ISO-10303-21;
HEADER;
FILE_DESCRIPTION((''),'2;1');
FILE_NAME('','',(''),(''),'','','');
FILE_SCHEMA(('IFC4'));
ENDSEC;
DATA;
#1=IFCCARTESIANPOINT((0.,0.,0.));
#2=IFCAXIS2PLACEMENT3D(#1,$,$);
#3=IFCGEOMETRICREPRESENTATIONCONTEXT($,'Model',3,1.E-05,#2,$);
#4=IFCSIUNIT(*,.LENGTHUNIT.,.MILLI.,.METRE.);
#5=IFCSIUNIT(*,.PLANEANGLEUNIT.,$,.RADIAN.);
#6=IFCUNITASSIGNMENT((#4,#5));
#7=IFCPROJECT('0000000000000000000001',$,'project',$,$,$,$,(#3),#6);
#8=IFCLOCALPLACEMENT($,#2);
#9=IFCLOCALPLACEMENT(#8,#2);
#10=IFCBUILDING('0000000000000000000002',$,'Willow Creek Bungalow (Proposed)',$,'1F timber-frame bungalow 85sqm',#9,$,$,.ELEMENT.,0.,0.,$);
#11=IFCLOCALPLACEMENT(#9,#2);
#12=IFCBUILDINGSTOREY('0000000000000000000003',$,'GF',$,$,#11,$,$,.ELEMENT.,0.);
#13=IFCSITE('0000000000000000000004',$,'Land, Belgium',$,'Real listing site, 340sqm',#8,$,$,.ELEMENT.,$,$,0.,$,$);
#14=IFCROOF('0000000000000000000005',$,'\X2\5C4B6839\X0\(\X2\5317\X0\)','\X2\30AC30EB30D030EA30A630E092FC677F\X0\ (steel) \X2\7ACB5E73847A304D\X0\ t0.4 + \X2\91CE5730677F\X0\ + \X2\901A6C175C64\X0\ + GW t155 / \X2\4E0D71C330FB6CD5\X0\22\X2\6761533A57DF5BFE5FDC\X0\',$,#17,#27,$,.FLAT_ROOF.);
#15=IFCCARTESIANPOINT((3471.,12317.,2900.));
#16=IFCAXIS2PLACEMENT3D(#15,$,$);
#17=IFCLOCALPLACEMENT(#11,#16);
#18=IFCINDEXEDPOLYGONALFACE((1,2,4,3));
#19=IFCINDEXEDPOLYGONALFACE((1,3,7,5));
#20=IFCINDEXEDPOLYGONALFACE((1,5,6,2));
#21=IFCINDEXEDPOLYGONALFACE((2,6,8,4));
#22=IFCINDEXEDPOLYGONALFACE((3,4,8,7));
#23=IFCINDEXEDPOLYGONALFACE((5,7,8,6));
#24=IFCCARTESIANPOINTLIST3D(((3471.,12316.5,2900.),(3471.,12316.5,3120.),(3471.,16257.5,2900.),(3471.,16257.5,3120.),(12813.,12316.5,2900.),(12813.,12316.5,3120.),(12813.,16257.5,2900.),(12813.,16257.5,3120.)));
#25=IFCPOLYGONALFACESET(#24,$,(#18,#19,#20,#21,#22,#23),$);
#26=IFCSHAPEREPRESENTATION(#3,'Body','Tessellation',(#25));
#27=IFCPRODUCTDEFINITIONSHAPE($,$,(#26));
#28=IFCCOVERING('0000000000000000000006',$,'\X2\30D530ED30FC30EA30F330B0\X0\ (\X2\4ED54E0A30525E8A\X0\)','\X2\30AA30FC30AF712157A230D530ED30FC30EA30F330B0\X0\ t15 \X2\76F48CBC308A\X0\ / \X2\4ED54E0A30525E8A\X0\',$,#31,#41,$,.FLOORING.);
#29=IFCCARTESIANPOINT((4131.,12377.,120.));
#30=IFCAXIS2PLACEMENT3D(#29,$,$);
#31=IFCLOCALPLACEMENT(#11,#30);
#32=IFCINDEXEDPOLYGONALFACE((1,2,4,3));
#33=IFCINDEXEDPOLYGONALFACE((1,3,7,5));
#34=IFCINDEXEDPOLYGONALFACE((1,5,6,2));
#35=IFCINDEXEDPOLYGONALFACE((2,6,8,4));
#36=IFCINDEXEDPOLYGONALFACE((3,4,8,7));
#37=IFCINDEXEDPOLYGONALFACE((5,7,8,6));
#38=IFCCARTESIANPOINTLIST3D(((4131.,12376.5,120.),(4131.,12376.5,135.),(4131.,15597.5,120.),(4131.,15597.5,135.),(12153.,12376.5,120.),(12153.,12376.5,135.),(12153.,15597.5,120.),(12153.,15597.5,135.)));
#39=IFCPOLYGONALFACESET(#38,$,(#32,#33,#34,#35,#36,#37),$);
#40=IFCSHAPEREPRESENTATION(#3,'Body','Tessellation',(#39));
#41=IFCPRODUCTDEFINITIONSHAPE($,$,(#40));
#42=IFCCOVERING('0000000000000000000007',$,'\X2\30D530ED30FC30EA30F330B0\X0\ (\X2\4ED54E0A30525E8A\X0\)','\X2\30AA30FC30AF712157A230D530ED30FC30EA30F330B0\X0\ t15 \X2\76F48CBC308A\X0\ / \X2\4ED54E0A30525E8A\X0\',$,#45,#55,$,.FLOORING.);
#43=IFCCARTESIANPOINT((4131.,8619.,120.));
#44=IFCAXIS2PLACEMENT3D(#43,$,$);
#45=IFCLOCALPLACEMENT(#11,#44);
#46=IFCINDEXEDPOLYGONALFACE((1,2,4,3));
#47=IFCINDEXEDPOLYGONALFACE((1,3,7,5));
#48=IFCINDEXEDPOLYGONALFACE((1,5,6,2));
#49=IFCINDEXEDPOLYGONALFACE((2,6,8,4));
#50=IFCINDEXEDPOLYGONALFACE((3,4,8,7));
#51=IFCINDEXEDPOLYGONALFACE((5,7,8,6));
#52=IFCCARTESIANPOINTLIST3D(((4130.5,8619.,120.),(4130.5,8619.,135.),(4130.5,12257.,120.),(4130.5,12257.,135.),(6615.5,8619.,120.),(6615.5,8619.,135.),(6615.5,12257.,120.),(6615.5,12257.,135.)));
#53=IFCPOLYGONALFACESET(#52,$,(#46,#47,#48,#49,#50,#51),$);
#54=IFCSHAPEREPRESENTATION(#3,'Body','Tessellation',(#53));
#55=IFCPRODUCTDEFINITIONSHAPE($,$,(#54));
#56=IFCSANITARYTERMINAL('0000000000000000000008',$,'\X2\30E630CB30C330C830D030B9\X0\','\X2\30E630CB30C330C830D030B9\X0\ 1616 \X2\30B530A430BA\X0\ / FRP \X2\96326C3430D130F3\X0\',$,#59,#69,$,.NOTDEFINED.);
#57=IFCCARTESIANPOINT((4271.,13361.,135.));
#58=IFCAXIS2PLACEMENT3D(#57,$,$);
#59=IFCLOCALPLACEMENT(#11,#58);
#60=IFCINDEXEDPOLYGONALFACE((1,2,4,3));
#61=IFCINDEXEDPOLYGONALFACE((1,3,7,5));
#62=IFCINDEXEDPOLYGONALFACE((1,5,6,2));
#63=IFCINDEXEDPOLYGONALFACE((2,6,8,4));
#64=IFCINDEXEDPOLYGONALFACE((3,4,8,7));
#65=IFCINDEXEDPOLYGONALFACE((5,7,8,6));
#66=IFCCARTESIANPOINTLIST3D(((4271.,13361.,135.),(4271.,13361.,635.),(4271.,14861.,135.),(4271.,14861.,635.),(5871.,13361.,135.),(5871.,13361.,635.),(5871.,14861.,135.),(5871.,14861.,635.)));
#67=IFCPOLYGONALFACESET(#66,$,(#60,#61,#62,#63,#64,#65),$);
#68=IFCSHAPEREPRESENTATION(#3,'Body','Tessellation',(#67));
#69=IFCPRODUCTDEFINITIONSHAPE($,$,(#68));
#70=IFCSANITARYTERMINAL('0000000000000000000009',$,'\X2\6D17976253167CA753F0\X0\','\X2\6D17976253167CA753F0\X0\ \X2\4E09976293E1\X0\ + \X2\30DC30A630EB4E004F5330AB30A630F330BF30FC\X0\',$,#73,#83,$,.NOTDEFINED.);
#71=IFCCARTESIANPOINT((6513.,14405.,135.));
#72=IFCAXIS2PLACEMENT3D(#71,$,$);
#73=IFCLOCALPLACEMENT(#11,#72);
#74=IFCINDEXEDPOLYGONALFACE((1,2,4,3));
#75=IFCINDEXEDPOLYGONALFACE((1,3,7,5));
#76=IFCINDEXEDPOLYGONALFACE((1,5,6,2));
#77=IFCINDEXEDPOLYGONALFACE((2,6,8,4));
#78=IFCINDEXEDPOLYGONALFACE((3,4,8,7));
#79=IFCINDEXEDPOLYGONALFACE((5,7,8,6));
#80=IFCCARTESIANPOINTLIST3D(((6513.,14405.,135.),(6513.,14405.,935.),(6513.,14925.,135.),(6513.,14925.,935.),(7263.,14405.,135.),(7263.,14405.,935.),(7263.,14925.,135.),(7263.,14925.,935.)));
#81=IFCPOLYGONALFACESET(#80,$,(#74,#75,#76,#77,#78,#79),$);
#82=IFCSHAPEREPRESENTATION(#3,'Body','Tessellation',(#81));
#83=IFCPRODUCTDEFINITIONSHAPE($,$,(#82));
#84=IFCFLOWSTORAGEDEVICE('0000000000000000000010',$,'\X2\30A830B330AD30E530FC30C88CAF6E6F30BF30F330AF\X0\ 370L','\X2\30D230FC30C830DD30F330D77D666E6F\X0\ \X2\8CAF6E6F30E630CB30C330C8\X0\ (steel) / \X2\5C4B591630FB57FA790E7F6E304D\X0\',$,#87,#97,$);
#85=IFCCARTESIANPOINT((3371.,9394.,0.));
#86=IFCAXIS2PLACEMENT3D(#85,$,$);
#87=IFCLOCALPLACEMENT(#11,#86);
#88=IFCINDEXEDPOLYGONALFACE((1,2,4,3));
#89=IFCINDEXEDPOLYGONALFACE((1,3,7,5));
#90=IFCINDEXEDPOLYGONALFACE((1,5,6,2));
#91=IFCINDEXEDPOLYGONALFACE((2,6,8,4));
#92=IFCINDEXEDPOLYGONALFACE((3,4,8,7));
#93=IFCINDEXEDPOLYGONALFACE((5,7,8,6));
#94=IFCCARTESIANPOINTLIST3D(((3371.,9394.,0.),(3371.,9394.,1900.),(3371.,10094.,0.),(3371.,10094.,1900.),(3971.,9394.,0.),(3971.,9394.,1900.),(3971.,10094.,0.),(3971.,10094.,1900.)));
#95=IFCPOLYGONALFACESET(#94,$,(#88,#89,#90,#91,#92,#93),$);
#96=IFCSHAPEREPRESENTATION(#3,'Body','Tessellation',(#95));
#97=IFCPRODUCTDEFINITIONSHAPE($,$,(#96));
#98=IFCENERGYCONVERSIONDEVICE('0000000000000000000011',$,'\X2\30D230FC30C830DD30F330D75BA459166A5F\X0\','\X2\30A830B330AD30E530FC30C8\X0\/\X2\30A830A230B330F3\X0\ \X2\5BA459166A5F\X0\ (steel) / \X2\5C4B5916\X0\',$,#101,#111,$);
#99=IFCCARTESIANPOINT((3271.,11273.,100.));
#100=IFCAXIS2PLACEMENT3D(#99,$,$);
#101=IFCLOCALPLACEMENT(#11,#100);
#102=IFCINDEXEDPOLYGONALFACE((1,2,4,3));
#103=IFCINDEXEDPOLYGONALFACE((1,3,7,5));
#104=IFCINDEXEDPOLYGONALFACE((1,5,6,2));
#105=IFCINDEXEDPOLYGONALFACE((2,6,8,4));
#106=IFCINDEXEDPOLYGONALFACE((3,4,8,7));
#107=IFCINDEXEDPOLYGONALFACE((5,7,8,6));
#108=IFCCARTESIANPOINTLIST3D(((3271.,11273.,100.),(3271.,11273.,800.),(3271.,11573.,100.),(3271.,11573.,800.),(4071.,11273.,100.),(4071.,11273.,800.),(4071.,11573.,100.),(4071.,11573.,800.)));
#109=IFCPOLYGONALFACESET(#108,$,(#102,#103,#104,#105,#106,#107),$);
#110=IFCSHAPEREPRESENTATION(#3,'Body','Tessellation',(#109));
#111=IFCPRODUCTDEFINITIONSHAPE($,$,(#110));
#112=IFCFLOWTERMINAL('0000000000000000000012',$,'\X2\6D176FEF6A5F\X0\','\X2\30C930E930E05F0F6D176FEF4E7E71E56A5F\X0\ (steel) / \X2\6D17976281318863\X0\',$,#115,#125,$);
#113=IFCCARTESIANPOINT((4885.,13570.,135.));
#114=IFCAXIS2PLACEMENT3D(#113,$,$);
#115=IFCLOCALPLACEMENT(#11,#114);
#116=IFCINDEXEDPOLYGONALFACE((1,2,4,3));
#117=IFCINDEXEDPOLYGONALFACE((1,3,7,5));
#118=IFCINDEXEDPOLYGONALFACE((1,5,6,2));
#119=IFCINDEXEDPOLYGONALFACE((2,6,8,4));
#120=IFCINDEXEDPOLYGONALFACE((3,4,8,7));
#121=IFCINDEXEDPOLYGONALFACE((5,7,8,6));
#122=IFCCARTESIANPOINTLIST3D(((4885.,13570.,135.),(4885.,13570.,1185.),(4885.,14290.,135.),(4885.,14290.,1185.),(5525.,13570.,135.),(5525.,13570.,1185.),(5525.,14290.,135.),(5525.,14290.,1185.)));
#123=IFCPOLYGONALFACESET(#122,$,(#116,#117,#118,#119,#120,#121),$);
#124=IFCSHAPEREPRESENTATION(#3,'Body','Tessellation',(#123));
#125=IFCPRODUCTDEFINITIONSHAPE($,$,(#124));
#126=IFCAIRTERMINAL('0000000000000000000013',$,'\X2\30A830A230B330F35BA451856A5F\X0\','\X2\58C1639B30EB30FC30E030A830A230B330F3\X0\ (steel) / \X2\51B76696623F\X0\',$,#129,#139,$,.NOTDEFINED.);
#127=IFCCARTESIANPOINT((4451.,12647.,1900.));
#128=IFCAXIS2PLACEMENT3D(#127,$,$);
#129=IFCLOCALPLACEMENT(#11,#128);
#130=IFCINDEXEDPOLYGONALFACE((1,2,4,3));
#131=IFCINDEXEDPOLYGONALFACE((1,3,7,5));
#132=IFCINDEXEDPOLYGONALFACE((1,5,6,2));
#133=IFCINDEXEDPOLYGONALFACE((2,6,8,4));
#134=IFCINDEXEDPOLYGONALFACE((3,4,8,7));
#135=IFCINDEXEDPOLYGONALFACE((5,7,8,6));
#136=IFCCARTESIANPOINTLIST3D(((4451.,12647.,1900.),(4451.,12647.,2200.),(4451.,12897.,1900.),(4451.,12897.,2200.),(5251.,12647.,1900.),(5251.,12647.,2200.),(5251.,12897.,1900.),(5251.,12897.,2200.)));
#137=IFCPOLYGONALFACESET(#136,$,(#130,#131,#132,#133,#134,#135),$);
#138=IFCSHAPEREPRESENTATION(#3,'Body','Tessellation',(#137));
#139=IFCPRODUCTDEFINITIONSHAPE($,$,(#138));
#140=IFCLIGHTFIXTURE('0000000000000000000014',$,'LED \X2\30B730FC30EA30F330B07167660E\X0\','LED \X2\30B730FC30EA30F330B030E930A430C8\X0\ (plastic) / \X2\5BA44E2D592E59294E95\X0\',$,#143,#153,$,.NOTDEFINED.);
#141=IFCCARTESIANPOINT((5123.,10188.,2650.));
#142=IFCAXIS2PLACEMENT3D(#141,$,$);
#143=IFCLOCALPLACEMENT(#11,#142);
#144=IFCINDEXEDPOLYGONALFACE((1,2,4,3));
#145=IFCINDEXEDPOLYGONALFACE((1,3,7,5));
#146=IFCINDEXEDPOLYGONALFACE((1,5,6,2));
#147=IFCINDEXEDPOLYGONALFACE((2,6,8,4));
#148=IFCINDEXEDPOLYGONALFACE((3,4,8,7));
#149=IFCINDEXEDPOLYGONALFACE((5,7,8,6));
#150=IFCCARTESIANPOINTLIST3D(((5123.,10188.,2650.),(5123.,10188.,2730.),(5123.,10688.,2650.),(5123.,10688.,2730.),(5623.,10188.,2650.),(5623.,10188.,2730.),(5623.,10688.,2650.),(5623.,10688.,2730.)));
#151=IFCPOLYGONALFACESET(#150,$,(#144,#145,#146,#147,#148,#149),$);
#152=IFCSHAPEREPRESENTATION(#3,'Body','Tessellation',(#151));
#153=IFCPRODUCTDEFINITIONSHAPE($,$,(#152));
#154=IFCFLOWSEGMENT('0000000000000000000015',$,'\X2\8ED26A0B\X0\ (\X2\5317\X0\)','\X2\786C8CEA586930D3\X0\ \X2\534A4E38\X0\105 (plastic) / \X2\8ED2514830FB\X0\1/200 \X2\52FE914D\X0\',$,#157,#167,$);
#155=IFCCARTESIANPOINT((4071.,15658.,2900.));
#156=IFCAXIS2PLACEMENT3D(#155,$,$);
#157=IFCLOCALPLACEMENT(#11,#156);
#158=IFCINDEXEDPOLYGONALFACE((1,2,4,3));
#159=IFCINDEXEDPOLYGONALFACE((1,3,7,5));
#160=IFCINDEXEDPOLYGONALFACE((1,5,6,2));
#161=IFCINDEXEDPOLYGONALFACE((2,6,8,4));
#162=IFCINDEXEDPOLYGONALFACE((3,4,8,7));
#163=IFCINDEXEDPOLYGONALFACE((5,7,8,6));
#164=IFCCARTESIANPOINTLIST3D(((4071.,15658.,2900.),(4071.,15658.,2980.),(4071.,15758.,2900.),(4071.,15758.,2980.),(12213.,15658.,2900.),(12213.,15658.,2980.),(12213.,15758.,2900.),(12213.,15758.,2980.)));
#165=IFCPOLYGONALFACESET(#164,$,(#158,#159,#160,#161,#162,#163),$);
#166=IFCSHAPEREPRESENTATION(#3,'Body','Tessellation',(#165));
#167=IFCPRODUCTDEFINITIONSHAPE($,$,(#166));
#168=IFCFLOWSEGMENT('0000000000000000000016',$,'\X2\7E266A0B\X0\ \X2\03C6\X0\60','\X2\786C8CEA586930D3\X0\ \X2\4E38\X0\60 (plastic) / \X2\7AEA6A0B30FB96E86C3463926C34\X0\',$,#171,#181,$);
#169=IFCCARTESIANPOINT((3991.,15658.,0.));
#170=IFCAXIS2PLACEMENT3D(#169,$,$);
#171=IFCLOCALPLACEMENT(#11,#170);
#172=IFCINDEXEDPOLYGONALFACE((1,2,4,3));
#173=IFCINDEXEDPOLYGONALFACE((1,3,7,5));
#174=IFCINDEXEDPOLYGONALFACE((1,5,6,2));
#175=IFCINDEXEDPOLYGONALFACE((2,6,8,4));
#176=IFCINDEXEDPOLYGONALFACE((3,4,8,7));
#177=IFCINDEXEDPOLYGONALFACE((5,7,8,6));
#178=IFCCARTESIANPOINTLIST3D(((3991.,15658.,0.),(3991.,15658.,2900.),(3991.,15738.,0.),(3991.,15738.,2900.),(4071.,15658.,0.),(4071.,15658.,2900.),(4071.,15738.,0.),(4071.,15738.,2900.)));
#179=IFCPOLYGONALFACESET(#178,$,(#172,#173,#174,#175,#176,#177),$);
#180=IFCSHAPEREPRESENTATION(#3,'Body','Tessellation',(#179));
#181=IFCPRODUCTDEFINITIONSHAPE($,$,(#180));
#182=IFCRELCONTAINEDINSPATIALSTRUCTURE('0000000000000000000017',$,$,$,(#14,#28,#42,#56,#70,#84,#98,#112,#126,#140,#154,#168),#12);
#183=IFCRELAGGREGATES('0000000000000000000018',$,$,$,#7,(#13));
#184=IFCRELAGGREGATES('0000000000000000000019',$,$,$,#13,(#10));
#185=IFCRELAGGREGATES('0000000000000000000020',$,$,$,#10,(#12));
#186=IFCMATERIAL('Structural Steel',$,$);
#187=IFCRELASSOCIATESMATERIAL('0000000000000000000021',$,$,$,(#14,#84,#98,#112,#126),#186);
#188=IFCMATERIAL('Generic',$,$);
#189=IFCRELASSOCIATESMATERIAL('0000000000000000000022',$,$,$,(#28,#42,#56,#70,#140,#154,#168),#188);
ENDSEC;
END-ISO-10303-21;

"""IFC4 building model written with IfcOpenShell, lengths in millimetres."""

from ifc_helpers import new_model, si_unit, frame, frame_2d, origin, place, context, project, spatial, rectangle, extrude, material, element, save


model = new_model("IFC4")

# Units and contexts
model_context = context("Model", 3, precision=1e-05, world=origin())
ifc_project = project(units=[si_unit("LENGTHUNIT", "METRE", prefix="MILLI"), si_unit("PLANEANGLEUNIT", "RADIAN")], contexts=[model_context])

# Site, building, storey
site_placement = place(None, origin())
site = spatial("IfcSite", under=ifc_project, at=site_placement, Name="Land, Belgium", ObjectType="Real listing site, 340sqm", CompositionType="ELEMENT", RefElevation=0.0)
building_placement = place(site_placement, origin())
building = spatial("IfcBuilding", under=site, at=building_placement, Name="Willow Creek Bungalow (Proposed)", ObjectType="1F timber-frame bungalow 85sqm", CompositionType="ELEMENT", ElevationOfRefHeight=0.0, ElevationOfTerrain=0.0)
storey_placement = place(building_placement, origin())
storey = spatial("IfcBuildingStorey", under=building, at=storey_placement, Name="GF", CompositionType="ELEMENT", Elevation=0.0)

# Roof
ifc_material_1 = material(Name="Structural Steel")
roof_placement = place(storey_placement, frame((3471.0, 12317.0, 2900.0)))
element("IfcRoof", 1, at=roof_placement, inside=storey, material=ifc_material_1, Name="屋根(北)", Description="ガルバリウム鋼板 (steel) 立平葺き t0.4 + 野地板 + 通気層 + GW t155 / 不燃・法22条区域対応", PredefinedType="FLAT_ROOF", context=model_context, shape_type="SweptSolid", body=[
    extrude(rectangle(XDim=9342.0, YDim=3941.0, at=frame_2d((4671.0, 1970.0))), frame((3471.0, 12317.0, 2900.0)), (0.0, 0.0, 1.0), 220.0),
])

# Coverings
ifc_material_2 = material(Name="Generic")
covering_1_placement = place(storey_placement, frame((4131.0, 12377.0, 120.0)))
element("IfcCovering", 2, at=covering_1_placement, inside=storey, material=ifc_material_2, Name="フローリング (仕上げ床)", Description="オーク無垢フローリング t15 直貼り / 仕上げ床", PredefinedType="FLOORING", context=model_context, shape_type="SweptSolid", body=[
    extrude(rectangle(XDim=8022.0, YDim=3221.0, at=frame_2d((4011.0, 1610.0))), frame((4131.0, 12377.0, 120.0)), (0.0, 0.0, 1.0), 15.0),
])
covering_2_placement = place(storey_placement, frame((4131.0, 8619.0, 120.0)))
element("IfcCovering", 3, at=covering_2_placement, inside=storey, material=ifc_material_2, Name="フローリング (仕上げ床)", Description="オーク無垢フローリング t15 直貼り / 仕上げ床", PredefinedType="FLOORING", context=model_context, shape_type="SweptSolid", body=[
    extrude(rectangle(XDim=2485.0, YDim=3638.0, at=frame_2d((1242.0, 1819.0))), frame((4131.0, 8619.0, 120.0)), (0.0, 0.0, 1.0), 15.0),
])

# Sanitary terminals
sanitary_terminal_1_placement = place(storey_placement, frame((4271.0, 13361.0, 135.0)))
element("IfcSanitaryTerminal", 4, at=sanitary_terminal_1_placement, inside=storey, material=ifc_material_2, Name="ユニットバス", Description="ユニットバス 1616 サイズ / FRP 防水パン", PredefinedType="NOTDEFINED", context=model_context, shape_type="SweptSolid", body=[
    extrude(rectangle(XDim=1600.0, YDim=1500.0, at=frame_2d((800.0, 750.0))), frame((4271.0, 13361.0, 135.0)), (0.0, 0.0, 1.0), 500.0),
])
sanitary_terminal_2_placement = place(storey_placement, frame((6513.0, 14405.0, 135.0)))
element("IfcSanitaryTerminal", 5, at=sanitary_terminal_2_placement, inside=storey, material=ifc_material_2, Name="洗面化粧台", Description="洗面化粧台 三面鏡 + ボウル一体カウンター", PredefinedType="NOTDEFINED", context=model_context, shape_type="SweptSolid", body=[
    extrude(rectangle(XDim=750.0, YDim=520.0, at=frame_2d((375.0, 260.0))), frame((6513.0, 14405.0, 135.0)), (0.0, 0.0, 1.0), 800.0),
])

# Flow storage device
flow_storage_device_placement = place(storey_placement, frame((3371.0, 9394.0, 0.0)))
element("IfcFlowStorageDevice", 6, at=flow_storage_device_placement, inside=storey, material=ifc_material_1, Name="エコキュート貯湯タンク 370L", Description="ヒートポンプ給湯 貯湯ユニット (steel) / 屋外・基礎置き", context=model_context, shape_type="SweptSolid", body=[
    extrude(rectangle(XDim=600.0, YDim=700.0, at=frame_2d((300.0, 350.0))), frame((3371.0, 9394.0, 0.0)), (0.0, 0.0, 1.0), 1900.0),
])

# Energy conversion device
energy_conversion_device_placement = place(storey_placement, frame((3271.0, 11273.0, 100.0)))
element("IfcEnergyConversionDevice", 7, at=energy_conversion_device_placement, inside=storey, material=ifc_material_1, Name="ヒートポンプ室外機", Description="エコキュート/エアコン 室外機 (steel) / 屋外", context=model_context, shape_type="SweptSolid", body=[
    extrude(rectangle(XDim=800.0, YDim=300.0, at=frame_2d((400.0, 150.0))), frame((3271.0, 11273.0, 100.0)), (0.0, 0.0, 1.0), 700.0),
])

# Flow terminal
flow_terminal_placement = place(storey_placement, frame((4885.0, 13570.0, 135.0)))
element("IfcFlowTerminal", 8, at=flow_terminal_placement, inside=storey, material=ifc_material_1, Name="洗濯機", Description="ドラム式洗濯乾燥機 (steel) / 洗面脱衣", context=model_context, shape_type="SweptSolid", body=[
    extrude(rectangle(XDim=640.0, YDim=720.0, at=frame_2d((320.0, 360.0))), frame((4885.0, 13570.0, 135.0)), (0.0, 0.0, 1.0), 1050.0),
])

# Air terminal
air_terminal_placement = place(storey_placement, frame((4451.0, 12647.0, 1900.0)))
element("IfcAirTerminal", 9, at=air_terminal_placement, inside=storey, material=ifc_material_1, Name="エアコン室内機", Description="壁掛ルームエアコン (steel) / 冷暖房", PredefinedType="NOTDEFINED", context=model_context, shape_type="SweptSolid", body=[
    extrude(rectangle(XDim=800.0, YDim=250.0, at=frame_2d((400.0, 125.0))), frame((4451.0, 12647.0, 1900.0)), (0.0, 0.0, 1.0), 300.0),
])

# Light fixture
light_fixture_placement = place(storey_placement, frame((5123.0, 10188.0, 2650.0)))
element("IfcLightFixture", 10, at=light_fixture_placement, inside=storey, material=ifc_material_2, Name="LED シーリング照明", Description="LED シーリングライト (plastic) / 室中央天井", PredefinedType="NOTDEFINED", context=model_context, shape_type="SweptSolid", body=[
    extrude(rectangle(XDim=500.0, YDim=500.0, at=frame_2d((250.0, 250.0))), frame((5123.0, 10188.0, 2650.0)), (0.0, 0.0, 1.0), 80.0),
])

# Flow segments
flow_segment_1_placement = place(storey_placement, frame((4071.0, 15658.0, 2900.0)))
element("IfcFlowSegment", 11, at=flow_segment_1_placement, inside=storey, material=ifc_material_2, Name="軒樋 (北)", Description="硬質塩ビ 半丸105 (plastic) / 軒先・1/200 勾配", context=model_context, shape_type="SweptSolid", body=[
    extrude(rectangle(XDim=8142.0, YDim=100.0, at=frame_2d((4071.0, 50.0))), frame((4071.0, 15658.0, 2900.0)), (0.0, 0.0, 1.0), 80.0),
])
flow_segment_2_placement = place(storey_placement, frame((3991.0, 15658.0, 0.0)))
element("IfcFlowSegment", 12, at=flow_segment_2_placement, inside=storey, material=ifc_material_2, Name="縦樋 φ60", Description="硬質塩ビ 丸60 (plastic) / 竪樋・雨水排水", context=model_context, shape_type="SweptSolid", body=[
    extrude(rectangle(XDim=80.0, YDim=80.0, at=frame_2d((40.0, 40.0))), frame((3991.0, 15658.0, 0.0)), (0.0, 0.0, 1.0), 2900.0),
])

save(model, "model.ifc")
